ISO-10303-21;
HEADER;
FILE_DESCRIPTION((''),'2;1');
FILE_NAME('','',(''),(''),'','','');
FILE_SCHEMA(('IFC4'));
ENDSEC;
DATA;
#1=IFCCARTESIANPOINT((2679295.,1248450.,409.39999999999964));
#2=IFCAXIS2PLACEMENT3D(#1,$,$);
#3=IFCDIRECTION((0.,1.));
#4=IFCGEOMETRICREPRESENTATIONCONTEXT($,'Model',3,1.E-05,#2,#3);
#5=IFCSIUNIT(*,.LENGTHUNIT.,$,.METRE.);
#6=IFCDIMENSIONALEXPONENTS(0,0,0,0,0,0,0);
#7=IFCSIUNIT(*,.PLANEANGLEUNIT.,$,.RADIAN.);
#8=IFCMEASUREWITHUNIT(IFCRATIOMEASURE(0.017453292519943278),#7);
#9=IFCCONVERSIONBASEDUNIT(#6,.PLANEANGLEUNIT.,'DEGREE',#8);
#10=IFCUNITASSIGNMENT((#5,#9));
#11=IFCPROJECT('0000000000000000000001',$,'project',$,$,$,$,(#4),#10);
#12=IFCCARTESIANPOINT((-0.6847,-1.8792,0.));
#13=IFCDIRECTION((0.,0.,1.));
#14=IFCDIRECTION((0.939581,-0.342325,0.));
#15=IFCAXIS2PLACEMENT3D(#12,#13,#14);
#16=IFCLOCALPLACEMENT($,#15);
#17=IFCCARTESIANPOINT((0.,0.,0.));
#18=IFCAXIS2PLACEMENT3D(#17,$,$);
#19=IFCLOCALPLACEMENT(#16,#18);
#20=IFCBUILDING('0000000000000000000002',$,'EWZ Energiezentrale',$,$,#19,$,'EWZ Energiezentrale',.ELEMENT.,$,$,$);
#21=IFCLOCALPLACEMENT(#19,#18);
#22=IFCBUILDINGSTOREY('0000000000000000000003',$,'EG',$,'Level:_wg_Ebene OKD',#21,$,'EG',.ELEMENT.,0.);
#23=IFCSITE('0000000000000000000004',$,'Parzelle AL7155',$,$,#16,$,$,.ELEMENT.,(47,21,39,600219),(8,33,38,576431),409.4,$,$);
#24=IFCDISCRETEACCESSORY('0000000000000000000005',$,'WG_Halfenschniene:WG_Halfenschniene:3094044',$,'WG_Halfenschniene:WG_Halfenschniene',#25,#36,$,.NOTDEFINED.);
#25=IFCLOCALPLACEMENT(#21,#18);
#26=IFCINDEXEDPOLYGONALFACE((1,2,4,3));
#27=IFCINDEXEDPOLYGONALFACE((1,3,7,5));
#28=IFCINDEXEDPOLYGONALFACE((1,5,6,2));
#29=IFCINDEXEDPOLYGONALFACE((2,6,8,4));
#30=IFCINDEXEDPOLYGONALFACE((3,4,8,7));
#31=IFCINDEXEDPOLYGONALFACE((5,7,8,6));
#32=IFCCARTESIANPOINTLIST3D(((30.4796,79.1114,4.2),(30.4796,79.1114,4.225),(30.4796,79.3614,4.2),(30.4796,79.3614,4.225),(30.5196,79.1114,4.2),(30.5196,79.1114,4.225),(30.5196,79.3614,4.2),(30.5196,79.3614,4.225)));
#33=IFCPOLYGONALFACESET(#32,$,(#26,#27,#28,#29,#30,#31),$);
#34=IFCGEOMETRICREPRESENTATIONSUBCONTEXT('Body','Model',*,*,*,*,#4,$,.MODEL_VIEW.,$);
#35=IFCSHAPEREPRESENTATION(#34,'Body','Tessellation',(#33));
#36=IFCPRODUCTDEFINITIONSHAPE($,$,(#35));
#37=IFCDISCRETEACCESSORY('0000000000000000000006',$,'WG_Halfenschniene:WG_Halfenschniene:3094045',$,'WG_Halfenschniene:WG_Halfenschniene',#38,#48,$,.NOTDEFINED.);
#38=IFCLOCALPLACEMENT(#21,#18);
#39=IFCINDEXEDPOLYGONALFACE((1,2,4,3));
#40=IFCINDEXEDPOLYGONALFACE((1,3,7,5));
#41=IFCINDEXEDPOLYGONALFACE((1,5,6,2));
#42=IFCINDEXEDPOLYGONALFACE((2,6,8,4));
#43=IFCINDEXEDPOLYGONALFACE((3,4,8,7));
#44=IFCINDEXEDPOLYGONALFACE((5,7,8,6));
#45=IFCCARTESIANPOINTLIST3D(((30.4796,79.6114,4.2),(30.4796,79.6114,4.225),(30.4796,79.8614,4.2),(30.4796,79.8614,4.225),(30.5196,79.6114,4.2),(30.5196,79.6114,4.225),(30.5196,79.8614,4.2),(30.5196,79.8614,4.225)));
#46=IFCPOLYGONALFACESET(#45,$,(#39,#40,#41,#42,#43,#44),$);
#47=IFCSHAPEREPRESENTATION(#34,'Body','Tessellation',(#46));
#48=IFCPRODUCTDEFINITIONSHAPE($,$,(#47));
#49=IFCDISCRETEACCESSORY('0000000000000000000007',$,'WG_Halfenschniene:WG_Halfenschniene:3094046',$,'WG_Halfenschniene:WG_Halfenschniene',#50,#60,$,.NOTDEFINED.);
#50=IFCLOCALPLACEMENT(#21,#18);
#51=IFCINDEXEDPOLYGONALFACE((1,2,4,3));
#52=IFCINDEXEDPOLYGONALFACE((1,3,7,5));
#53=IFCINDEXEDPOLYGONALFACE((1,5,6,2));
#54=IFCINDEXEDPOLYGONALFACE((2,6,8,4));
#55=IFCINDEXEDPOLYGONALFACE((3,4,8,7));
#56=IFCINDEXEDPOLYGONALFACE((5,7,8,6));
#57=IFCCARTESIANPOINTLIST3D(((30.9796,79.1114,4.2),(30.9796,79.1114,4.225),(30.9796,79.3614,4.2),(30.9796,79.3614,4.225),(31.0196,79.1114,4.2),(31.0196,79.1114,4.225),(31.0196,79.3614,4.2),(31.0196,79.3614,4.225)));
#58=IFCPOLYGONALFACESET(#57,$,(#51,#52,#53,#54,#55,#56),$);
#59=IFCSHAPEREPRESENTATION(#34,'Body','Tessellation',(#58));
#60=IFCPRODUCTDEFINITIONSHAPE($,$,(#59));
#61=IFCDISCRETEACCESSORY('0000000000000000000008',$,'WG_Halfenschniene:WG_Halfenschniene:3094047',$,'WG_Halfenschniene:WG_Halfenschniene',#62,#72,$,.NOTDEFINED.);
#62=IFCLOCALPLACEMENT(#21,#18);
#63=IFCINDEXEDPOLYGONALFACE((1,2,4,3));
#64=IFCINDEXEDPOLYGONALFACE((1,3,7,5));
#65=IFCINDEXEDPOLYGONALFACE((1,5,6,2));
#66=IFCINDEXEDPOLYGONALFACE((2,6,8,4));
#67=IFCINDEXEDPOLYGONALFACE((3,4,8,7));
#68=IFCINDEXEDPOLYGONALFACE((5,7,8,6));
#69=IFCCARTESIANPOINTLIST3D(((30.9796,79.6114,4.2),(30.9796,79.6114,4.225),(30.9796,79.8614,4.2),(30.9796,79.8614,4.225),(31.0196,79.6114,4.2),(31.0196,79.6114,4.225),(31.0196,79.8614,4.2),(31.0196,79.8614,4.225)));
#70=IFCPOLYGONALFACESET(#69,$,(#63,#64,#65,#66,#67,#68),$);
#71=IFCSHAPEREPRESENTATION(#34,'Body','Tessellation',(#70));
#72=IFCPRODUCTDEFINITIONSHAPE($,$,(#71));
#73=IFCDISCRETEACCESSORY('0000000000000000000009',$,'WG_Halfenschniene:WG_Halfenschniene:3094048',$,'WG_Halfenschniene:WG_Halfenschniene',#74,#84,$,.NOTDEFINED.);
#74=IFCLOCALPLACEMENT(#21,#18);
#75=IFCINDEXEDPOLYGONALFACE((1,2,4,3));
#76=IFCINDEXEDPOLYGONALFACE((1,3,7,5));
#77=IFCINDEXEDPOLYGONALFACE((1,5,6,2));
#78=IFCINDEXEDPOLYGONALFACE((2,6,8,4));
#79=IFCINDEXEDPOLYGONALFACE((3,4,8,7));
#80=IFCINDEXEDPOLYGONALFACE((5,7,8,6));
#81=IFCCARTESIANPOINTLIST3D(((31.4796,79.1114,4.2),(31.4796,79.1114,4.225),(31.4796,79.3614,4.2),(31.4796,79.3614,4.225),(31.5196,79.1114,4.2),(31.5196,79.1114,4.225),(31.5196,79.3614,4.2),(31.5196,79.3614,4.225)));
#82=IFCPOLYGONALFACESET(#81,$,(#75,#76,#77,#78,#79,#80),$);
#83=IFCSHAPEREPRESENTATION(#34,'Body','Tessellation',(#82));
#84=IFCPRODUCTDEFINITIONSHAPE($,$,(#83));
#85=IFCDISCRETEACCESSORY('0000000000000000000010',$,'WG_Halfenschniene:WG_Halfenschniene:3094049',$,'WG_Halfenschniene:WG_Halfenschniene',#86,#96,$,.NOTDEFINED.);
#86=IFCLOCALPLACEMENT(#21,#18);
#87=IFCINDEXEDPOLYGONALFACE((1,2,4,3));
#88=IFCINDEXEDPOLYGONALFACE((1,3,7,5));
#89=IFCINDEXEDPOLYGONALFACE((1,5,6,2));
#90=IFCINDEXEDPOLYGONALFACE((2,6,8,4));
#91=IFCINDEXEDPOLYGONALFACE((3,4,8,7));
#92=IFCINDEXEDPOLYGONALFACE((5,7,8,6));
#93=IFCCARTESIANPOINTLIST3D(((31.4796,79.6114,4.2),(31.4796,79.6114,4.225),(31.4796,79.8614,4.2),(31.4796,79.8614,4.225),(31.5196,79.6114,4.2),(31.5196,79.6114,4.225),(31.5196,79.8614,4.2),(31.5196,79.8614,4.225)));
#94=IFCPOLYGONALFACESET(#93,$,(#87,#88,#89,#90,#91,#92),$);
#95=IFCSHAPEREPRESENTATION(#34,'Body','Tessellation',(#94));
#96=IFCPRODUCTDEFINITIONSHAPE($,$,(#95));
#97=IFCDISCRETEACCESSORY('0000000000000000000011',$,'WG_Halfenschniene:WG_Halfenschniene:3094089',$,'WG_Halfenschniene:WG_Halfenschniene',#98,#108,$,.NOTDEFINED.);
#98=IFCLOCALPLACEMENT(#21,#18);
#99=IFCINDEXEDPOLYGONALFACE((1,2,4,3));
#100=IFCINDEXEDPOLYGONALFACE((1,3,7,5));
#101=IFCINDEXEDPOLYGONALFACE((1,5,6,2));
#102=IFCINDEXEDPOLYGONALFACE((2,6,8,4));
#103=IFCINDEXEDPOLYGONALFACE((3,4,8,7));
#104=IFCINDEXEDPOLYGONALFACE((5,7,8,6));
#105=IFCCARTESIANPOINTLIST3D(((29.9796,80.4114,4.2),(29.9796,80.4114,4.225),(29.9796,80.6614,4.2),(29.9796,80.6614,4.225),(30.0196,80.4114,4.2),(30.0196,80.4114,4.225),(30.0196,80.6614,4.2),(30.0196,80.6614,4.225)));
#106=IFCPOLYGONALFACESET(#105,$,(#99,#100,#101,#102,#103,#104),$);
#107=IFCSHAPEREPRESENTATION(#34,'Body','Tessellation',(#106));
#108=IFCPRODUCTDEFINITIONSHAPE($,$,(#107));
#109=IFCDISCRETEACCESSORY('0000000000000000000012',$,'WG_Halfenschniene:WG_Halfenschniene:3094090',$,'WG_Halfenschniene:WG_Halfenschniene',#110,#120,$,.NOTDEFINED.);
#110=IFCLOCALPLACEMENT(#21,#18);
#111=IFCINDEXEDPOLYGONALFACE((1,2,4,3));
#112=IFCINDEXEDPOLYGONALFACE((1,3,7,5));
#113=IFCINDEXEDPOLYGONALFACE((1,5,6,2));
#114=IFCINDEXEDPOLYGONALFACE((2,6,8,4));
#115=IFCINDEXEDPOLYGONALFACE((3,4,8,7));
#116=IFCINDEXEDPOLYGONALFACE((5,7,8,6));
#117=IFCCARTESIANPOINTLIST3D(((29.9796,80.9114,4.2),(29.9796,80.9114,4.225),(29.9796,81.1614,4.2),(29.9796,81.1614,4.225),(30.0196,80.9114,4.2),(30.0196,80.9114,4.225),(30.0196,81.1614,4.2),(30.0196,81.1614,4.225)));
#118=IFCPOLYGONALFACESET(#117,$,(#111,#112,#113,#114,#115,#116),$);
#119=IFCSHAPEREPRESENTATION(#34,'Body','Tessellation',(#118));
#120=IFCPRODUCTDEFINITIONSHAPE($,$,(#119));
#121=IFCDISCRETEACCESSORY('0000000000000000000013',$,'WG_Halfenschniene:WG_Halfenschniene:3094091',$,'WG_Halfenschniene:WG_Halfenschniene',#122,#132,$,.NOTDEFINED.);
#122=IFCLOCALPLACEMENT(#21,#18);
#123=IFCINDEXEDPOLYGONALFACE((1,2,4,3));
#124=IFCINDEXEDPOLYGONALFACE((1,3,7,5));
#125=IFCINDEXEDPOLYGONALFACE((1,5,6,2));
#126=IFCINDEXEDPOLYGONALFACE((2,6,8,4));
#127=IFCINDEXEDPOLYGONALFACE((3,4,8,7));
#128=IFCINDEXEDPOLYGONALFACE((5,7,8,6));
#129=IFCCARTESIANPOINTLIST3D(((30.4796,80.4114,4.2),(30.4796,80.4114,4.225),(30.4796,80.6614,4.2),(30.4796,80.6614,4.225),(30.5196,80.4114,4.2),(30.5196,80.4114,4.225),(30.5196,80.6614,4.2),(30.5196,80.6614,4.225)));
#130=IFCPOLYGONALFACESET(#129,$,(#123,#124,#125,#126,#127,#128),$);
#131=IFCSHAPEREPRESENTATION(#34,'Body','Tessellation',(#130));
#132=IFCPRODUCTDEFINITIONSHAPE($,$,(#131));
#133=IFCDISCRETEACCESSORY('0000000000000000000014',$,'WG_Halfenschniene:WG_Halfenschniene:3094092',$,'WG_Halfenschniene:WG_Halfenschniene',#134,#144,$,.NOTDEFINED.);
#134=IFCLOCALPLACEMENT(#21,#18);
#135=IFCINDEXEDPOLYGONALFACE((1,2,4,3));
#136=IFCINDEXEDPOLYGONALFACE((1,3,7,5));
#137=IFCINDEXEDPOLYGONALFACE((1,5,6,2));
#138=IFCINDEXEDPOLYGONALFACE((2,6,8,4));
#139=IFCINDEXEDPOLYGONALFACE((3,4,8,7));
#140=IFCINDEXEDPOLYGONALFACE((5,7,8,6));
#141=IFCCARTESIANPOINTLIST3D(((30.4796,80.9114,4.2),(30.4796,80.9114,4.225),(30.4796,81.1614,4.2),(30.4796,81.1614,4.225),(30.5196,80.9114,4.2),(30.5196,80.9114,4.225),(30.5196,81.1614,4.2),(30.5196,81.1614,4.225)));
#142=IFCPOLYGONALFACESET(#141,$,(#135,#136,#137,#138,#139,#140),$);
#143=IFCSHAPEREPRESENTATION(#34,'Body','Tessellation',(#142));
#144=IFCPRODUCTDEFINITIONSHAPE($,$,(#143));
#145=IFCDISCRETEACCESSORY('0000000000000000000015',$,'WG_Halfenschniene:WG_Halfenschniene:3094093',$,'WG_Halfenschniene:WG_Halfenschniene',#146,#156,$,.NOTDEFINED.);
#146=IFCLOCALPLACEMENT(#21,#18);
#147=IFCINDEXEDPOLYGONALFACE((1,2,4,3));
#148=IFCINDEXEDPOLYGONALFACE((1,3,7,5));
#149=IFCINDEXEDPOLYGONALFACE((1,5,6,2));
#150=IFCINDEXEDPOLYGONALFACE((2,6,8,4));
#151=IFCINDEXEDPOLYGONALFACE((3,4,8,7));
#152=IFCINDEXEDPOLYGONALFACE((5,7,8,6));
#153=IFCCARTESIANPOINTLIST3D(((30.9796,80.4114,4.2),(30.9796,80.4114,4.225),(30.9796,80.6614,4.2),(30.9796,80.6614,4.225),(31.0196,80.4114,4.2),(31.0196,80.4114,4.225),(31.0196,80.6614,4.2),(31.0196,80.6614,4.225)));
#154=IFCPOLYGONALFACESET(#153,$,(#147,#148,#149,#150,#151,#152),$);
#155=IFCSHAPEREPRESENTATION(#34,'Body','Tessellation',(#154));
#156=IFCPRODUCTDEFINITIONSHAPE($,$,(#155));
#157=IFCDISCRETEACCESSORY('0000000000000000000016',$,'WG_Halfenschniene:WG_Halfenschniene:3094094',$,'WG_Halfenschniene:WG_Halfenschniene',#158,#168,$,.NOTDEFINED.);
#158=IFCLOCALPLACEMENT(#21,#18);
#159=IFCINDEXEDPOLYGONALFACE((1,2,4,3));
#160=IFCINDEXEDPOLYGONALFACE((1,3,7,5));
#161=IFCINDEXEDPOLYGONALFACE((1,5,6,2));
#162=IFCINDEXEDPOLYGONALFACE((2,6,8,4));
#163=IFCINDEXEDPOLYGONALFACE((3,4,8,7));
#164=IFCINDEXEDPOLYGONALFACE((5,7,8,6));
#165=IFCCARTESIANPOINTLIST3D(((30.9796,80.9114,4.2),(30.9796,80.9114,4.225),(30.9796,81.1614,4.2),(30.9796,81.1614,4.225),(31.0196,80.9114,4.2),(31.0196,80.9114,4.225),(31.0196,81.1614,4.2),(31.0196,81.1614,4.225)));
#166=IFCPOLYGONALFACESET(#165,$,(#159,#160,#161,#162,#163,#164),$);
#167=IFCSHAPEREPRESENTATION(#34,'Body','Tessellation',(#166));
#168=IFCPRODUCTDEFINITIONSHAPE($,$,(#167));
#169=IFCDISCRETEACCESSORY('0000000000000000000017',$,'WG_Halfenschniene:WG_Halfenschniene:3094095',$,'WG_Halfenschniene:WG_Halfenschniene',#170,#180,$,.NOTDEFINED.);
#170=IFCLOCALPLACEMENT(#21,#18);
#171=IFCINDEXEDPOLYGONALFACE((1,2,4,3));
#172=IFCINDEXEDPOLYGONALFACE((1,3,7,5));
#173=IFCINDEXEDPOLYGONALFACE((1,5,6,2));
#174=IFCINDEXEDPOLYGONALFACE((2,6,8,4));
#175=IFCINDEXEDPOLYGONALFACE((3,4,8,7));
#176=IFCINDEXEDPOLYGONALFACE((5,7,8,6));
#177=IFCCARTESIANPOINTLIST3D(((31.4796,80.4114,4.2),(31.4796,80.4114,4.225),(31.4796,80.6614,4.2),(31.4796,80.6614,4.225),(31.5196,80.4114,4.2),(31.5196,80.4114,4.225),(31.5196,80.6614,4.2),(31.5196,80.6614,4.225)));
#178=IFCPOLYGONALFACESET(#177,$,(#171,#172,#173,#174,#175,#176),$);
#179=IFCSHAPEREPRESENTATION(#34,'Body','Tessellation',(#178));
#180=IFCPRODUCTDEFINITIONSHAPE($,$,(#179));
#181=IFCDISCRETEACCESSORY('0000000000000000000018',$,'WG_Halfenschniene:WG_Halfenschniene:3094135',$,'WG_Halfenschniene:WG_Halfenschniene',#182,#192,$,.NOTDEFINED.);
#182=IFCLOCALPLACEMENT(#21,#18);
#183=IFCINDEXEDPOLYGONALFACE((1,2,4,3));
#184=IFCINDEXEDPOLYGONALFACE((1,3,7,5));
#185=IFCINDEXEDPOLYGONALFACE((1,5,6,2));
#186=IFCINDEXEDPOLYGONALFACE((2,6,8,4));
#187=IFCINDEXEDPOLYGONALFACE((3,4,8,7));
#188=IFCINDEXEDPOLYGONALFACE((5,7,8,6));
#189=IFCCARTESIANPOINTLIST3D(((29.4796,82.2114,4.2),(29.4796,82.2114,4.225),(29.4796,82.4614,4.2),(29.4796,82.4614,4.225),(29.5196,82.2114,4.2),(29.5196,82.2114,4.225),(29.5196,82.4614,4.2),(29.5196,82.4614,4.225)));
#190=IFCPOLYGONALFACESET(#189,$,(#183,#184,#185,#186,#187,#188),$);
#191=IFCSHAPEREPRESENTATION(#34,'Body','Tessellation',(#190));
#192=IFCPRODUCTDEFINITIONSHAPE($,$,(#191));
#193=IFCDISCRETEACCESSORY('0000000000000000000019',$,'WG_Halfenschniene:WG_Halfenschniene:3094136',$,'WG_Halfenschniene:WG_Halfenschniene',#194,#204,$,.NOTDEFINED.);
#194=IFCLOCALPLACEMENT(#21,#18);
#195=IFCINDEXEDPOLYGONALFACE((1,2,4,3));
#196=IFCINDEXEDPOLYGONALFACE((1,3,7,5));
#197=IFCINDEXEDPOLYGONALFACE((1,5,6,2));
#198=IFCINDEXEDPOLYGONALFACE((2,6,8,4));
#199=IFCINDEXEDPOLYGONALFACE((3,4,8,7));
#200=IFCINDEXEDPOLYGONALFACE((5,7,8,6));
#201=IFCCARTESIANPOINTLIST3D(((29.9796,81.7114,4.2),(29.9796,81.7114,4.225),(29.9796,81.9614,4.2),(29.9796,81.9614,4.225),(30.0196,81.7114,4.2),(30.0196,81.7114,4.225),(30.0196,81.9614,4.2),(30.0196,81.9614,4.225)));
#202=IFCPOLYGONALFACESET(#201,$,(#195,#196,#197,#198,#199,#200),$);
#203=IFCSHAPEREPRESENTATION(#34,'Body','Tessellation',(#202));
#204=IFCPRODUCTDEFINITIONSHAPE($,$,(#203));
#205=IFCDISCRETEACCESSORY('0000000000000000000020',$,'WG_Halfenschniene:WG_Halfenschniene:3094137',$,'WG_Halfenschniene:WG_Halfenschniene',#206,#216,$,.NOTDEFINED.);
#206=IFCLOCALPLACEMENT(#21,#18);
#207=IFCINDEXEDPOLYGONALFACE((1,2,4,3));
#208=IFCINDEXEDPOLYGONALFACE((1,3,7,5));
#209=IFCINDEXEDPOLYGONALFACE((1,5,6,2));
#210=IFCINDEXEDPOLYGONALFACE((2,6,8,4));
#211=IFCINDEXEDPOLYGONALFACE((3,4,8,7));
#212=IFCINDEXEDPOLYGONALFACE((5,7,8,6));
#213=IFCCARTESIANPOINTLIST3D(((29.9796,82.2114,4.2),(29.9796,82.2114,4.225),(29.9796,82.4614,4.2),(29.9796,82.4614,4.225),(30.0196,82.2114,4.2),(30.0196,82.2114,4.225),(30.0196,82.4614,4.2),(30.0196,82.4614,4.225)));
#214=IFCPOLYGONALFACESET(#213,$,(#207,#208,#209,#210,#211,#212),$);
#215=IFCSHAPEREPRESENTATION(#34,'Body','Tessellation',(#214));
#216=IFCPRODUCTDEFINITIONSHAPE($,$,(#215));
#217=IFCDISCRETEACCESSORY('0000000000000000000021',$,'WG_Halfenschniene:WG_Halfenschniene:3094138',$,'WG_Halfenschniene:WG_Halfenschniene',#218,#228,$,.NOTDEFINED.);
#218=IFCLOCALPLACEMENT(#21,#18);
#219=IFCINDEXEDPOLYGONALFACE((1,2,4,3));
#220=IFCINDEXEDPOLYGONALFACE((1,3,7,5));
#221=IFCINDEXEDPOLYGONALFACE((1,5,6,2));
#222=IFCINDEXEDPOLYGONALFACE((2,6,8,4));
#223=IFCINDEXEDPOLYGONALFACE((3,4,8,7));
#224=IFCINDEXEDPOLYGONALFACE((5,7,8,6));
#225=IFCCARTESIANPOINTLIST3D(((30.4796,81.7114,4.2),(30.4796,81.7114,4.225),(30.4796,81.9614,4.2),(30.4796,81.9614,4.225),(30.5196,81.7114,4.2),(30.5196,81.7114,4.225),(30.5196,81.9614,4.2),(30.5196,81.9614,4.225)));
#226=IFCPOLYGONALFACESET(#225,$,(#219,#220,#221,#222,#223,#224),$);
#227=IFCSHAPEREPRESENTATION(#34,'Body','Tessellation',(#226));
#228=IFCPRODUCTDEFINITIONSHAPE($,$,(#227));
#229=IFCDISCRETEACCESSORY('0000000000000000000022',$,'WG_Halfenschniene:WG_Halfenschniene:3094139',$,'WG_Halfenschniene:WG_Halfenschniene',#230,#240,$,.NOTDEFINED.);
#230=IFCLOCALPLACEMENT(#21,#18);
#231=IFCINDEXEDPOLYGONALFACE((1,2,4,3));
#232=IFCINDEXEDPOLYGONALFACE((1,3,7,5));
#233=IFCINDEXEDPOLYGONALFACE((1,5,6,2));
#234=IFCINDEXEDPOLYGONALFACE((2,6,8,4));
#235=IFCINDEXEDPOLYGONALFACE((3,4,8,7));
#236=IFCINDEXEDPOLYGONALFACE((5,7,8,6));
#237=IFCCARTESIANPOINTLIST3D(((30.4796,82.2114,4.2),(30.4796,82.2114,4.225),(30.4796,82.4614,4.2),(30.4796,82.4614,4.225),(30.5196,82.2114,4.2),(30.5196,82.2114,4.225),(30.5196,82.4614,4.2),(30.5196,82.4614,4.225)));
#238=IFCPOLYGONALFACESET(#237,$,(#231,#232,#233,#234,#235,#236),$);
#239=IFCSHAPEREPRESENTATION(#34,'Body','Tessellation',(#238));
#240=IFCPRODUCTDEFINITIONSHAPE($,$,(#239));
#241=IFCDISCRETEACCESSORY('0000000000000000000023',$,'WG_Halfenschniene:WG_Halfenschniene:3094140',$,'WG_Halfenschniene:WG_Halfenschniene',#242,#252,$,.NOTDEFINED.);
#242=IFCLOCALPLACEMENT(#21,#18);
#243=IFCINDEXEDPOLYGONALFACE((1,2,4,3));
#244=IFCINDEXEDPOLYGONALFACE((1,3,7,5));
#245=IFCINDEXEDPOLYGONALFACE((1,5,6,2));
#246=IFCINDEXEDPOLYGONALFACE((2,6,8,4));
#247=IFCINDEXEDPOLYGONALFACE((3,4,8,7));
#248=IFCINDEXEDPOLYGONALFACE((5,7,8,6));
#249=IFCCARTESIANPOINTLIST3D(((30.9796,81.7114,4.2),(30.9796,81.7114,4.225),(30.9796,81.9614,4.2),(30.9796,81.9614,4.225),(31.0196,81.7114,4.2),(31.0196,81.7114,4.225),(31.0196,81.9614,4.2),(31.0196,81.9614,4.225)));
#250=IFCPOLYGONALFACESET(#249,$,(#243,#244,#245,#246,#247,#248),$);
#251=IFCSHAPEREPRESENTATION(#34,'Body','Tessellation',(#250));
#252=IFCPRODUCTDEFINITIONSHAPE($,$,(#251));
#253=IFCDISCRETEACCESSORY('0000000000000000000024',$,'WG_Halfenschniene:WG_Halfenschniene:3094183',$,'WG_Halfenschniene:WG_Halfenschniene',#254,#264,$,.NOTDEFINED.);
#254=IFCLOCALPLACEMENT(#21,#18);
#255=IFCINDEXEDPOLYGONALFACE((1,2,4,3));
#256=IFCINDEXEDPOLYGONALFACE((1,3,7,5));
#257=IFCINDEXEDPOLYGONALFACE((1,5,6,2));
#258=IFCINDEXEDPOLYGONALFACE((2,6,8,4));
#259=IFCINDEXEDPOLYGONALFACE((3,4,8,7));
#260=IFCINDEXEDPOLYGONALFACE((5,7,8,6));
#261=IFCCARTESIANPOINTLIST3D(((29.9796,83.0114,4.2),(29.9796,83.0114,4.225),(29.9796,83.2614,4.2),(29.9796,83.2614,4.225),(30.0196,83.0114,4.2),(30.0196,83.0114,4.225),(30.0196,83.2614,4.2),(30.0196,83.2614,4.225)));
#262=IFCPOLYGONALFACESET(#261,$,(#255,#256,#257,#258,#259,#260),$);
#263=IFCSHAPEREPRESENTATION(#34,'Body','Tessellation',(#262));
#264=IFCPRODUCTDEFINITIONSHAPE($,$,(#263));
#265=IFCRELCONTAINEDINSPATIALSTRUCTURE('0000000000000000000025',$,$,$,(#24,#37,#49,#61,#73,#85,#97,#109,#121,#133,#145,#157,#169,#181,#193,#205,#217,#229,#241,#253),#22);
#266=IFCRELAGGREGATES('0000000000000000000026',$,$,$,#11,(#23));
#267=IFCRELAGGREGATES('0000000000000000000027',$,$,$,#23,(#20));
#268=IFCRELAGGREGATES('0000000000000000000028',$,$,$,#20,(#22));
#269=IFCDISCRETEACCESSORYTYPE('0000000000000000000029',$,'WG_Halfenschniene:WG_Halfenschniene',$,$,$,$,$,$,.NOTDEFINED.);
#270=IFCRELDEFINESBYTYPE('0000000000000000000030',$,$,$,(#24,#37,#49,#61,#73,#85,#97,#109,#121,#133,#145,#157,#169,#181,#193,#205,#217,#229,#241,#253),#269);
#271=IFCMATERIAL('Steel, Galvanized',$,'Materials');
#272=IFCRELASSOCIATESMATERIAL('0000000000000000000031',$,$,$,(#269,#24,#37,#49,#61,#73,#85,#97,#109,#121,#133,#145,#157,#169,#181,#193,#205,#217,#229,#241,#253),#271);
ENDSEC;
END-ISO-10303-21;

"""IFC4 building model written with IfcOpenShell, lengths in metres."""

from ifc_helpers import new_model, entity, si_unit, converted_unit, direction, frame, origin, place, context, subcontext, project, spatial, indexed_curve, outline, extrude, source, transform, mapped, material, type_object, element, save


model = new_model("IFC4")

# Units and contexts
model_context = context("Model", 3, precision=1e-05, world=frame((2679295.0, 1248450.0, 409.39999999999964)), true_north=direction((0.0, 1.0)))
body_context = subcontext(model_context, "Body", "Model", "MODEL_VIEW")
ifc_project = project(units=[si_unit("LENGTHUNIT", "METRE"), converted_unit("PLANEANGLEUNIT", "DEGREE", entity("IfcRatioMeasure", 0.017453292519943278), si_unit("PLANEANGLEUNIT", "RADIAN"), dimensions=[0, 0, 0, 0, 0, 0, 0])], contexts=[model_context])

# Site, building, storey
site_placement = place(None, frame((-0.6847, -1.8792, 0.0), z_axis=(0.0, 0.0, 1.0), x_axis=(0.939581, -0.342325, 0.0)))
site = spatial("IfcSite", under=ifc_project, at=site_placement, Name="Parzelle AL7155", CompositionType="ELEMENT", RefLatitude=(47, 21, 39, 600219), RefLongitude=(8, 33, 38, 576431), RefElevation=409.4)
building_placement = place(site_placement, origin())
building = spatial("IfcBuilding", under=site, at=building_placement, Name="EWZ Energiezentrale", LongName="EWZ Energiezentrale", CompositionType="ELEMENT")
storey_placement = place(building_placement, origin())
storey = spatial("IfcBuildingStorey", under=building, at=storey_placement, Name="EG", ObjectType="Level:_wg_Ebene OKD", LongName="EG", CompositionType="ELEMENT", Elevation=0.0)

# Discrete accessories
ifc_material = material(Name="Steel, Galvanized", Category="Materials")
discrete_accessory_type = type_object("IfcDiscreteAccessoryType", Name="WG_Halfenschniene:WG_Halfenschniene", PredefinedType="NOTDEFINED", material=ifc_material)
shared_shape = source(origin(), body_context, "Body", "SweptSolid", [
    extrude(outline(indexed_curve([(-0.125, -0.02), (0.125, -0.02), (0.125, 0.02), (-0.125, 0.02), (-0.125, -0.02)], self_intersect=False)), frame((0.125, 0.0, -0.0125)), (0.0, 0.0, 1.0), 0.025),
])
for number, where, z_axis, x_axis, name in (
    (1, (30.4996, 79.1114, 4.2125), (0.0, 0.0, -1.0), (0.0, 1.0, 0.0), "WG_Halfenschniene:WG_Halfenschniene:3094044"),
    (2, (30.4996, 79.6114, 4.2125), (0.0, 0.0, -1.0), (0.0, 1.0, 0.0), "WG_Halfenschniene:WG_Halfenschniene:3094045"),
    (3, (30.9996, 79.1114, 4.2125), (0.0, 0.0, -1.0), (0.0, 1.0, 0.0), "WG_Halfenschniene:WG_Halfenschniene:3094046"),
    (4, (30.9996, 79.6114, 4.2125), (0.0, 0.0, -1.0), (0.0, 1.0, 0.0), "WG_Halfenschniene:WG_Halfenschniene:3094047"),
    (5, (31.4996, 79.1114, 4.2125), (0.0, 0.0, -1.0), (0.0, 1.0, 0.0), "WG_Halfenschniene:WG_Halfenschniene:3094048"),
    (6, (31.4996, 79.6114, 4.2125), (0.0, 0.0, -1.0), (0.0, 1.0, 0.0), "WG_Halfenschniene:WG_Halfenschniene:3094049"),
    (7, (29.9996, 80.4114, 4.2125), (0.0, 0.0, -1.0), (0.0, 1.0, 0.0), "WG_Halfenschniene:WG_Halfenschniene:3094089"),
    (8, (29.9996, 80.9114, 4.2125), (0.0, 0.0, -1.0), (0.0, 1.0, 0.0), "WG_Halfenschniene:WG_Halfenschniene:3094090"),
    (9, (30.4996, 80.4114, 4.2125), (0.0, 0.0, -1.0), (0.0, 1.0, 0.0), "WG_Halfenschniene:WG_Halfenschniene:3094091"),
    (10, (30.4996, 80.9114, 4.2125), (0.0, 0.0, -1.0), (0.0, 1.0, 0.0), "WG_Halfenschniene:WG_Halfenschniene:3094092"),
    (11, (30.9996, 80.4114, 4.2125), (0.0, 0.0, -1.0), (0.0, 1.0, 0.0), "WG_Halfenschniene:WG_Halfenschniene:3094093"),
    (12, (30.9996, 80.9114, 4.2125), (0.0, 0.0, -1.0), (0.0, 1.0, 0.0), "WG_Halfenschniene:WG_Halfenschniene:3094094"),
    (13, (31.4996, 80.4114, 4.2125), (0.0, 0.0, -1.0), (0.0, 1.0, 0.0), "WG_Halfenschniene:WG_Halfenschniene:3094095"),
    (14, (29.4996, 82.2114, 4.2125), (0.0, 0.0, -1.0), (0.0, 1.0, 0.0), "WG_Halfenschniene:WG_Halfenschniene:3094135"),
    (15, (29.9996, 81.7114, 4.2125), (0.0, 0.0, -1.0), (0.0, 1.0, 0.0), "WG_Halfenschniene:WG_Halfenschniene:3094136"),
    (16, (29.9996, 82.2114, 4.2125), (0.0, 0.0, -1.0), (0.0, 1.0, 0.0), "WG_Halfenschniene:WG_Halfenschniene:3094137"),
    (17, (30.4996, 81.7114, 4.2125), (0.0, 0.0, -1.0), (0.0, 1.0, 0.0), "WG_Halfenschniene:WG_Halfenschniene:3094138"),
    (18, (30.4996, 82.2114, 4.2125), (0.0, 0.0, -1.0), (0.0, 1.0, 0.0), "WG_Halfenschniene:WG_Halfenschniene:3094139"),
    (19, (30.9996, 81.7114, 4.2125), (0.0, 0.0, -1.0), (0.0, 1.0, 0.0), "WG_Halfenschniene:WG_Halfenschniene:3094140"),
    (20, (29.9996, 83.0114, 4.2125), (0.0, 0.0, -1.0), (0.0, 1.0, 0.0), "WG_Halfenschniene:WG_Halfenschniene:3094183"),
):
    element("IfcDiscreteAccessory", number, at=place(storey_placement, frame(where, z_axis=z_axis, x_axis=x_axis)), inside=storey, type_object=discrete_accessory_type, material=ifc_material, Name=name, ObjectType="WG_Halfenschniene:WG_Halfenschniene", PredefinedType="NOTDEFINED", context=body_context, shape_type="MappedRepresentation", body=[
        mapped(shared_shape, transform((0.0, 0.0, 0.0), scale=1.0)),
    ])

save(model, "model.ifc")
